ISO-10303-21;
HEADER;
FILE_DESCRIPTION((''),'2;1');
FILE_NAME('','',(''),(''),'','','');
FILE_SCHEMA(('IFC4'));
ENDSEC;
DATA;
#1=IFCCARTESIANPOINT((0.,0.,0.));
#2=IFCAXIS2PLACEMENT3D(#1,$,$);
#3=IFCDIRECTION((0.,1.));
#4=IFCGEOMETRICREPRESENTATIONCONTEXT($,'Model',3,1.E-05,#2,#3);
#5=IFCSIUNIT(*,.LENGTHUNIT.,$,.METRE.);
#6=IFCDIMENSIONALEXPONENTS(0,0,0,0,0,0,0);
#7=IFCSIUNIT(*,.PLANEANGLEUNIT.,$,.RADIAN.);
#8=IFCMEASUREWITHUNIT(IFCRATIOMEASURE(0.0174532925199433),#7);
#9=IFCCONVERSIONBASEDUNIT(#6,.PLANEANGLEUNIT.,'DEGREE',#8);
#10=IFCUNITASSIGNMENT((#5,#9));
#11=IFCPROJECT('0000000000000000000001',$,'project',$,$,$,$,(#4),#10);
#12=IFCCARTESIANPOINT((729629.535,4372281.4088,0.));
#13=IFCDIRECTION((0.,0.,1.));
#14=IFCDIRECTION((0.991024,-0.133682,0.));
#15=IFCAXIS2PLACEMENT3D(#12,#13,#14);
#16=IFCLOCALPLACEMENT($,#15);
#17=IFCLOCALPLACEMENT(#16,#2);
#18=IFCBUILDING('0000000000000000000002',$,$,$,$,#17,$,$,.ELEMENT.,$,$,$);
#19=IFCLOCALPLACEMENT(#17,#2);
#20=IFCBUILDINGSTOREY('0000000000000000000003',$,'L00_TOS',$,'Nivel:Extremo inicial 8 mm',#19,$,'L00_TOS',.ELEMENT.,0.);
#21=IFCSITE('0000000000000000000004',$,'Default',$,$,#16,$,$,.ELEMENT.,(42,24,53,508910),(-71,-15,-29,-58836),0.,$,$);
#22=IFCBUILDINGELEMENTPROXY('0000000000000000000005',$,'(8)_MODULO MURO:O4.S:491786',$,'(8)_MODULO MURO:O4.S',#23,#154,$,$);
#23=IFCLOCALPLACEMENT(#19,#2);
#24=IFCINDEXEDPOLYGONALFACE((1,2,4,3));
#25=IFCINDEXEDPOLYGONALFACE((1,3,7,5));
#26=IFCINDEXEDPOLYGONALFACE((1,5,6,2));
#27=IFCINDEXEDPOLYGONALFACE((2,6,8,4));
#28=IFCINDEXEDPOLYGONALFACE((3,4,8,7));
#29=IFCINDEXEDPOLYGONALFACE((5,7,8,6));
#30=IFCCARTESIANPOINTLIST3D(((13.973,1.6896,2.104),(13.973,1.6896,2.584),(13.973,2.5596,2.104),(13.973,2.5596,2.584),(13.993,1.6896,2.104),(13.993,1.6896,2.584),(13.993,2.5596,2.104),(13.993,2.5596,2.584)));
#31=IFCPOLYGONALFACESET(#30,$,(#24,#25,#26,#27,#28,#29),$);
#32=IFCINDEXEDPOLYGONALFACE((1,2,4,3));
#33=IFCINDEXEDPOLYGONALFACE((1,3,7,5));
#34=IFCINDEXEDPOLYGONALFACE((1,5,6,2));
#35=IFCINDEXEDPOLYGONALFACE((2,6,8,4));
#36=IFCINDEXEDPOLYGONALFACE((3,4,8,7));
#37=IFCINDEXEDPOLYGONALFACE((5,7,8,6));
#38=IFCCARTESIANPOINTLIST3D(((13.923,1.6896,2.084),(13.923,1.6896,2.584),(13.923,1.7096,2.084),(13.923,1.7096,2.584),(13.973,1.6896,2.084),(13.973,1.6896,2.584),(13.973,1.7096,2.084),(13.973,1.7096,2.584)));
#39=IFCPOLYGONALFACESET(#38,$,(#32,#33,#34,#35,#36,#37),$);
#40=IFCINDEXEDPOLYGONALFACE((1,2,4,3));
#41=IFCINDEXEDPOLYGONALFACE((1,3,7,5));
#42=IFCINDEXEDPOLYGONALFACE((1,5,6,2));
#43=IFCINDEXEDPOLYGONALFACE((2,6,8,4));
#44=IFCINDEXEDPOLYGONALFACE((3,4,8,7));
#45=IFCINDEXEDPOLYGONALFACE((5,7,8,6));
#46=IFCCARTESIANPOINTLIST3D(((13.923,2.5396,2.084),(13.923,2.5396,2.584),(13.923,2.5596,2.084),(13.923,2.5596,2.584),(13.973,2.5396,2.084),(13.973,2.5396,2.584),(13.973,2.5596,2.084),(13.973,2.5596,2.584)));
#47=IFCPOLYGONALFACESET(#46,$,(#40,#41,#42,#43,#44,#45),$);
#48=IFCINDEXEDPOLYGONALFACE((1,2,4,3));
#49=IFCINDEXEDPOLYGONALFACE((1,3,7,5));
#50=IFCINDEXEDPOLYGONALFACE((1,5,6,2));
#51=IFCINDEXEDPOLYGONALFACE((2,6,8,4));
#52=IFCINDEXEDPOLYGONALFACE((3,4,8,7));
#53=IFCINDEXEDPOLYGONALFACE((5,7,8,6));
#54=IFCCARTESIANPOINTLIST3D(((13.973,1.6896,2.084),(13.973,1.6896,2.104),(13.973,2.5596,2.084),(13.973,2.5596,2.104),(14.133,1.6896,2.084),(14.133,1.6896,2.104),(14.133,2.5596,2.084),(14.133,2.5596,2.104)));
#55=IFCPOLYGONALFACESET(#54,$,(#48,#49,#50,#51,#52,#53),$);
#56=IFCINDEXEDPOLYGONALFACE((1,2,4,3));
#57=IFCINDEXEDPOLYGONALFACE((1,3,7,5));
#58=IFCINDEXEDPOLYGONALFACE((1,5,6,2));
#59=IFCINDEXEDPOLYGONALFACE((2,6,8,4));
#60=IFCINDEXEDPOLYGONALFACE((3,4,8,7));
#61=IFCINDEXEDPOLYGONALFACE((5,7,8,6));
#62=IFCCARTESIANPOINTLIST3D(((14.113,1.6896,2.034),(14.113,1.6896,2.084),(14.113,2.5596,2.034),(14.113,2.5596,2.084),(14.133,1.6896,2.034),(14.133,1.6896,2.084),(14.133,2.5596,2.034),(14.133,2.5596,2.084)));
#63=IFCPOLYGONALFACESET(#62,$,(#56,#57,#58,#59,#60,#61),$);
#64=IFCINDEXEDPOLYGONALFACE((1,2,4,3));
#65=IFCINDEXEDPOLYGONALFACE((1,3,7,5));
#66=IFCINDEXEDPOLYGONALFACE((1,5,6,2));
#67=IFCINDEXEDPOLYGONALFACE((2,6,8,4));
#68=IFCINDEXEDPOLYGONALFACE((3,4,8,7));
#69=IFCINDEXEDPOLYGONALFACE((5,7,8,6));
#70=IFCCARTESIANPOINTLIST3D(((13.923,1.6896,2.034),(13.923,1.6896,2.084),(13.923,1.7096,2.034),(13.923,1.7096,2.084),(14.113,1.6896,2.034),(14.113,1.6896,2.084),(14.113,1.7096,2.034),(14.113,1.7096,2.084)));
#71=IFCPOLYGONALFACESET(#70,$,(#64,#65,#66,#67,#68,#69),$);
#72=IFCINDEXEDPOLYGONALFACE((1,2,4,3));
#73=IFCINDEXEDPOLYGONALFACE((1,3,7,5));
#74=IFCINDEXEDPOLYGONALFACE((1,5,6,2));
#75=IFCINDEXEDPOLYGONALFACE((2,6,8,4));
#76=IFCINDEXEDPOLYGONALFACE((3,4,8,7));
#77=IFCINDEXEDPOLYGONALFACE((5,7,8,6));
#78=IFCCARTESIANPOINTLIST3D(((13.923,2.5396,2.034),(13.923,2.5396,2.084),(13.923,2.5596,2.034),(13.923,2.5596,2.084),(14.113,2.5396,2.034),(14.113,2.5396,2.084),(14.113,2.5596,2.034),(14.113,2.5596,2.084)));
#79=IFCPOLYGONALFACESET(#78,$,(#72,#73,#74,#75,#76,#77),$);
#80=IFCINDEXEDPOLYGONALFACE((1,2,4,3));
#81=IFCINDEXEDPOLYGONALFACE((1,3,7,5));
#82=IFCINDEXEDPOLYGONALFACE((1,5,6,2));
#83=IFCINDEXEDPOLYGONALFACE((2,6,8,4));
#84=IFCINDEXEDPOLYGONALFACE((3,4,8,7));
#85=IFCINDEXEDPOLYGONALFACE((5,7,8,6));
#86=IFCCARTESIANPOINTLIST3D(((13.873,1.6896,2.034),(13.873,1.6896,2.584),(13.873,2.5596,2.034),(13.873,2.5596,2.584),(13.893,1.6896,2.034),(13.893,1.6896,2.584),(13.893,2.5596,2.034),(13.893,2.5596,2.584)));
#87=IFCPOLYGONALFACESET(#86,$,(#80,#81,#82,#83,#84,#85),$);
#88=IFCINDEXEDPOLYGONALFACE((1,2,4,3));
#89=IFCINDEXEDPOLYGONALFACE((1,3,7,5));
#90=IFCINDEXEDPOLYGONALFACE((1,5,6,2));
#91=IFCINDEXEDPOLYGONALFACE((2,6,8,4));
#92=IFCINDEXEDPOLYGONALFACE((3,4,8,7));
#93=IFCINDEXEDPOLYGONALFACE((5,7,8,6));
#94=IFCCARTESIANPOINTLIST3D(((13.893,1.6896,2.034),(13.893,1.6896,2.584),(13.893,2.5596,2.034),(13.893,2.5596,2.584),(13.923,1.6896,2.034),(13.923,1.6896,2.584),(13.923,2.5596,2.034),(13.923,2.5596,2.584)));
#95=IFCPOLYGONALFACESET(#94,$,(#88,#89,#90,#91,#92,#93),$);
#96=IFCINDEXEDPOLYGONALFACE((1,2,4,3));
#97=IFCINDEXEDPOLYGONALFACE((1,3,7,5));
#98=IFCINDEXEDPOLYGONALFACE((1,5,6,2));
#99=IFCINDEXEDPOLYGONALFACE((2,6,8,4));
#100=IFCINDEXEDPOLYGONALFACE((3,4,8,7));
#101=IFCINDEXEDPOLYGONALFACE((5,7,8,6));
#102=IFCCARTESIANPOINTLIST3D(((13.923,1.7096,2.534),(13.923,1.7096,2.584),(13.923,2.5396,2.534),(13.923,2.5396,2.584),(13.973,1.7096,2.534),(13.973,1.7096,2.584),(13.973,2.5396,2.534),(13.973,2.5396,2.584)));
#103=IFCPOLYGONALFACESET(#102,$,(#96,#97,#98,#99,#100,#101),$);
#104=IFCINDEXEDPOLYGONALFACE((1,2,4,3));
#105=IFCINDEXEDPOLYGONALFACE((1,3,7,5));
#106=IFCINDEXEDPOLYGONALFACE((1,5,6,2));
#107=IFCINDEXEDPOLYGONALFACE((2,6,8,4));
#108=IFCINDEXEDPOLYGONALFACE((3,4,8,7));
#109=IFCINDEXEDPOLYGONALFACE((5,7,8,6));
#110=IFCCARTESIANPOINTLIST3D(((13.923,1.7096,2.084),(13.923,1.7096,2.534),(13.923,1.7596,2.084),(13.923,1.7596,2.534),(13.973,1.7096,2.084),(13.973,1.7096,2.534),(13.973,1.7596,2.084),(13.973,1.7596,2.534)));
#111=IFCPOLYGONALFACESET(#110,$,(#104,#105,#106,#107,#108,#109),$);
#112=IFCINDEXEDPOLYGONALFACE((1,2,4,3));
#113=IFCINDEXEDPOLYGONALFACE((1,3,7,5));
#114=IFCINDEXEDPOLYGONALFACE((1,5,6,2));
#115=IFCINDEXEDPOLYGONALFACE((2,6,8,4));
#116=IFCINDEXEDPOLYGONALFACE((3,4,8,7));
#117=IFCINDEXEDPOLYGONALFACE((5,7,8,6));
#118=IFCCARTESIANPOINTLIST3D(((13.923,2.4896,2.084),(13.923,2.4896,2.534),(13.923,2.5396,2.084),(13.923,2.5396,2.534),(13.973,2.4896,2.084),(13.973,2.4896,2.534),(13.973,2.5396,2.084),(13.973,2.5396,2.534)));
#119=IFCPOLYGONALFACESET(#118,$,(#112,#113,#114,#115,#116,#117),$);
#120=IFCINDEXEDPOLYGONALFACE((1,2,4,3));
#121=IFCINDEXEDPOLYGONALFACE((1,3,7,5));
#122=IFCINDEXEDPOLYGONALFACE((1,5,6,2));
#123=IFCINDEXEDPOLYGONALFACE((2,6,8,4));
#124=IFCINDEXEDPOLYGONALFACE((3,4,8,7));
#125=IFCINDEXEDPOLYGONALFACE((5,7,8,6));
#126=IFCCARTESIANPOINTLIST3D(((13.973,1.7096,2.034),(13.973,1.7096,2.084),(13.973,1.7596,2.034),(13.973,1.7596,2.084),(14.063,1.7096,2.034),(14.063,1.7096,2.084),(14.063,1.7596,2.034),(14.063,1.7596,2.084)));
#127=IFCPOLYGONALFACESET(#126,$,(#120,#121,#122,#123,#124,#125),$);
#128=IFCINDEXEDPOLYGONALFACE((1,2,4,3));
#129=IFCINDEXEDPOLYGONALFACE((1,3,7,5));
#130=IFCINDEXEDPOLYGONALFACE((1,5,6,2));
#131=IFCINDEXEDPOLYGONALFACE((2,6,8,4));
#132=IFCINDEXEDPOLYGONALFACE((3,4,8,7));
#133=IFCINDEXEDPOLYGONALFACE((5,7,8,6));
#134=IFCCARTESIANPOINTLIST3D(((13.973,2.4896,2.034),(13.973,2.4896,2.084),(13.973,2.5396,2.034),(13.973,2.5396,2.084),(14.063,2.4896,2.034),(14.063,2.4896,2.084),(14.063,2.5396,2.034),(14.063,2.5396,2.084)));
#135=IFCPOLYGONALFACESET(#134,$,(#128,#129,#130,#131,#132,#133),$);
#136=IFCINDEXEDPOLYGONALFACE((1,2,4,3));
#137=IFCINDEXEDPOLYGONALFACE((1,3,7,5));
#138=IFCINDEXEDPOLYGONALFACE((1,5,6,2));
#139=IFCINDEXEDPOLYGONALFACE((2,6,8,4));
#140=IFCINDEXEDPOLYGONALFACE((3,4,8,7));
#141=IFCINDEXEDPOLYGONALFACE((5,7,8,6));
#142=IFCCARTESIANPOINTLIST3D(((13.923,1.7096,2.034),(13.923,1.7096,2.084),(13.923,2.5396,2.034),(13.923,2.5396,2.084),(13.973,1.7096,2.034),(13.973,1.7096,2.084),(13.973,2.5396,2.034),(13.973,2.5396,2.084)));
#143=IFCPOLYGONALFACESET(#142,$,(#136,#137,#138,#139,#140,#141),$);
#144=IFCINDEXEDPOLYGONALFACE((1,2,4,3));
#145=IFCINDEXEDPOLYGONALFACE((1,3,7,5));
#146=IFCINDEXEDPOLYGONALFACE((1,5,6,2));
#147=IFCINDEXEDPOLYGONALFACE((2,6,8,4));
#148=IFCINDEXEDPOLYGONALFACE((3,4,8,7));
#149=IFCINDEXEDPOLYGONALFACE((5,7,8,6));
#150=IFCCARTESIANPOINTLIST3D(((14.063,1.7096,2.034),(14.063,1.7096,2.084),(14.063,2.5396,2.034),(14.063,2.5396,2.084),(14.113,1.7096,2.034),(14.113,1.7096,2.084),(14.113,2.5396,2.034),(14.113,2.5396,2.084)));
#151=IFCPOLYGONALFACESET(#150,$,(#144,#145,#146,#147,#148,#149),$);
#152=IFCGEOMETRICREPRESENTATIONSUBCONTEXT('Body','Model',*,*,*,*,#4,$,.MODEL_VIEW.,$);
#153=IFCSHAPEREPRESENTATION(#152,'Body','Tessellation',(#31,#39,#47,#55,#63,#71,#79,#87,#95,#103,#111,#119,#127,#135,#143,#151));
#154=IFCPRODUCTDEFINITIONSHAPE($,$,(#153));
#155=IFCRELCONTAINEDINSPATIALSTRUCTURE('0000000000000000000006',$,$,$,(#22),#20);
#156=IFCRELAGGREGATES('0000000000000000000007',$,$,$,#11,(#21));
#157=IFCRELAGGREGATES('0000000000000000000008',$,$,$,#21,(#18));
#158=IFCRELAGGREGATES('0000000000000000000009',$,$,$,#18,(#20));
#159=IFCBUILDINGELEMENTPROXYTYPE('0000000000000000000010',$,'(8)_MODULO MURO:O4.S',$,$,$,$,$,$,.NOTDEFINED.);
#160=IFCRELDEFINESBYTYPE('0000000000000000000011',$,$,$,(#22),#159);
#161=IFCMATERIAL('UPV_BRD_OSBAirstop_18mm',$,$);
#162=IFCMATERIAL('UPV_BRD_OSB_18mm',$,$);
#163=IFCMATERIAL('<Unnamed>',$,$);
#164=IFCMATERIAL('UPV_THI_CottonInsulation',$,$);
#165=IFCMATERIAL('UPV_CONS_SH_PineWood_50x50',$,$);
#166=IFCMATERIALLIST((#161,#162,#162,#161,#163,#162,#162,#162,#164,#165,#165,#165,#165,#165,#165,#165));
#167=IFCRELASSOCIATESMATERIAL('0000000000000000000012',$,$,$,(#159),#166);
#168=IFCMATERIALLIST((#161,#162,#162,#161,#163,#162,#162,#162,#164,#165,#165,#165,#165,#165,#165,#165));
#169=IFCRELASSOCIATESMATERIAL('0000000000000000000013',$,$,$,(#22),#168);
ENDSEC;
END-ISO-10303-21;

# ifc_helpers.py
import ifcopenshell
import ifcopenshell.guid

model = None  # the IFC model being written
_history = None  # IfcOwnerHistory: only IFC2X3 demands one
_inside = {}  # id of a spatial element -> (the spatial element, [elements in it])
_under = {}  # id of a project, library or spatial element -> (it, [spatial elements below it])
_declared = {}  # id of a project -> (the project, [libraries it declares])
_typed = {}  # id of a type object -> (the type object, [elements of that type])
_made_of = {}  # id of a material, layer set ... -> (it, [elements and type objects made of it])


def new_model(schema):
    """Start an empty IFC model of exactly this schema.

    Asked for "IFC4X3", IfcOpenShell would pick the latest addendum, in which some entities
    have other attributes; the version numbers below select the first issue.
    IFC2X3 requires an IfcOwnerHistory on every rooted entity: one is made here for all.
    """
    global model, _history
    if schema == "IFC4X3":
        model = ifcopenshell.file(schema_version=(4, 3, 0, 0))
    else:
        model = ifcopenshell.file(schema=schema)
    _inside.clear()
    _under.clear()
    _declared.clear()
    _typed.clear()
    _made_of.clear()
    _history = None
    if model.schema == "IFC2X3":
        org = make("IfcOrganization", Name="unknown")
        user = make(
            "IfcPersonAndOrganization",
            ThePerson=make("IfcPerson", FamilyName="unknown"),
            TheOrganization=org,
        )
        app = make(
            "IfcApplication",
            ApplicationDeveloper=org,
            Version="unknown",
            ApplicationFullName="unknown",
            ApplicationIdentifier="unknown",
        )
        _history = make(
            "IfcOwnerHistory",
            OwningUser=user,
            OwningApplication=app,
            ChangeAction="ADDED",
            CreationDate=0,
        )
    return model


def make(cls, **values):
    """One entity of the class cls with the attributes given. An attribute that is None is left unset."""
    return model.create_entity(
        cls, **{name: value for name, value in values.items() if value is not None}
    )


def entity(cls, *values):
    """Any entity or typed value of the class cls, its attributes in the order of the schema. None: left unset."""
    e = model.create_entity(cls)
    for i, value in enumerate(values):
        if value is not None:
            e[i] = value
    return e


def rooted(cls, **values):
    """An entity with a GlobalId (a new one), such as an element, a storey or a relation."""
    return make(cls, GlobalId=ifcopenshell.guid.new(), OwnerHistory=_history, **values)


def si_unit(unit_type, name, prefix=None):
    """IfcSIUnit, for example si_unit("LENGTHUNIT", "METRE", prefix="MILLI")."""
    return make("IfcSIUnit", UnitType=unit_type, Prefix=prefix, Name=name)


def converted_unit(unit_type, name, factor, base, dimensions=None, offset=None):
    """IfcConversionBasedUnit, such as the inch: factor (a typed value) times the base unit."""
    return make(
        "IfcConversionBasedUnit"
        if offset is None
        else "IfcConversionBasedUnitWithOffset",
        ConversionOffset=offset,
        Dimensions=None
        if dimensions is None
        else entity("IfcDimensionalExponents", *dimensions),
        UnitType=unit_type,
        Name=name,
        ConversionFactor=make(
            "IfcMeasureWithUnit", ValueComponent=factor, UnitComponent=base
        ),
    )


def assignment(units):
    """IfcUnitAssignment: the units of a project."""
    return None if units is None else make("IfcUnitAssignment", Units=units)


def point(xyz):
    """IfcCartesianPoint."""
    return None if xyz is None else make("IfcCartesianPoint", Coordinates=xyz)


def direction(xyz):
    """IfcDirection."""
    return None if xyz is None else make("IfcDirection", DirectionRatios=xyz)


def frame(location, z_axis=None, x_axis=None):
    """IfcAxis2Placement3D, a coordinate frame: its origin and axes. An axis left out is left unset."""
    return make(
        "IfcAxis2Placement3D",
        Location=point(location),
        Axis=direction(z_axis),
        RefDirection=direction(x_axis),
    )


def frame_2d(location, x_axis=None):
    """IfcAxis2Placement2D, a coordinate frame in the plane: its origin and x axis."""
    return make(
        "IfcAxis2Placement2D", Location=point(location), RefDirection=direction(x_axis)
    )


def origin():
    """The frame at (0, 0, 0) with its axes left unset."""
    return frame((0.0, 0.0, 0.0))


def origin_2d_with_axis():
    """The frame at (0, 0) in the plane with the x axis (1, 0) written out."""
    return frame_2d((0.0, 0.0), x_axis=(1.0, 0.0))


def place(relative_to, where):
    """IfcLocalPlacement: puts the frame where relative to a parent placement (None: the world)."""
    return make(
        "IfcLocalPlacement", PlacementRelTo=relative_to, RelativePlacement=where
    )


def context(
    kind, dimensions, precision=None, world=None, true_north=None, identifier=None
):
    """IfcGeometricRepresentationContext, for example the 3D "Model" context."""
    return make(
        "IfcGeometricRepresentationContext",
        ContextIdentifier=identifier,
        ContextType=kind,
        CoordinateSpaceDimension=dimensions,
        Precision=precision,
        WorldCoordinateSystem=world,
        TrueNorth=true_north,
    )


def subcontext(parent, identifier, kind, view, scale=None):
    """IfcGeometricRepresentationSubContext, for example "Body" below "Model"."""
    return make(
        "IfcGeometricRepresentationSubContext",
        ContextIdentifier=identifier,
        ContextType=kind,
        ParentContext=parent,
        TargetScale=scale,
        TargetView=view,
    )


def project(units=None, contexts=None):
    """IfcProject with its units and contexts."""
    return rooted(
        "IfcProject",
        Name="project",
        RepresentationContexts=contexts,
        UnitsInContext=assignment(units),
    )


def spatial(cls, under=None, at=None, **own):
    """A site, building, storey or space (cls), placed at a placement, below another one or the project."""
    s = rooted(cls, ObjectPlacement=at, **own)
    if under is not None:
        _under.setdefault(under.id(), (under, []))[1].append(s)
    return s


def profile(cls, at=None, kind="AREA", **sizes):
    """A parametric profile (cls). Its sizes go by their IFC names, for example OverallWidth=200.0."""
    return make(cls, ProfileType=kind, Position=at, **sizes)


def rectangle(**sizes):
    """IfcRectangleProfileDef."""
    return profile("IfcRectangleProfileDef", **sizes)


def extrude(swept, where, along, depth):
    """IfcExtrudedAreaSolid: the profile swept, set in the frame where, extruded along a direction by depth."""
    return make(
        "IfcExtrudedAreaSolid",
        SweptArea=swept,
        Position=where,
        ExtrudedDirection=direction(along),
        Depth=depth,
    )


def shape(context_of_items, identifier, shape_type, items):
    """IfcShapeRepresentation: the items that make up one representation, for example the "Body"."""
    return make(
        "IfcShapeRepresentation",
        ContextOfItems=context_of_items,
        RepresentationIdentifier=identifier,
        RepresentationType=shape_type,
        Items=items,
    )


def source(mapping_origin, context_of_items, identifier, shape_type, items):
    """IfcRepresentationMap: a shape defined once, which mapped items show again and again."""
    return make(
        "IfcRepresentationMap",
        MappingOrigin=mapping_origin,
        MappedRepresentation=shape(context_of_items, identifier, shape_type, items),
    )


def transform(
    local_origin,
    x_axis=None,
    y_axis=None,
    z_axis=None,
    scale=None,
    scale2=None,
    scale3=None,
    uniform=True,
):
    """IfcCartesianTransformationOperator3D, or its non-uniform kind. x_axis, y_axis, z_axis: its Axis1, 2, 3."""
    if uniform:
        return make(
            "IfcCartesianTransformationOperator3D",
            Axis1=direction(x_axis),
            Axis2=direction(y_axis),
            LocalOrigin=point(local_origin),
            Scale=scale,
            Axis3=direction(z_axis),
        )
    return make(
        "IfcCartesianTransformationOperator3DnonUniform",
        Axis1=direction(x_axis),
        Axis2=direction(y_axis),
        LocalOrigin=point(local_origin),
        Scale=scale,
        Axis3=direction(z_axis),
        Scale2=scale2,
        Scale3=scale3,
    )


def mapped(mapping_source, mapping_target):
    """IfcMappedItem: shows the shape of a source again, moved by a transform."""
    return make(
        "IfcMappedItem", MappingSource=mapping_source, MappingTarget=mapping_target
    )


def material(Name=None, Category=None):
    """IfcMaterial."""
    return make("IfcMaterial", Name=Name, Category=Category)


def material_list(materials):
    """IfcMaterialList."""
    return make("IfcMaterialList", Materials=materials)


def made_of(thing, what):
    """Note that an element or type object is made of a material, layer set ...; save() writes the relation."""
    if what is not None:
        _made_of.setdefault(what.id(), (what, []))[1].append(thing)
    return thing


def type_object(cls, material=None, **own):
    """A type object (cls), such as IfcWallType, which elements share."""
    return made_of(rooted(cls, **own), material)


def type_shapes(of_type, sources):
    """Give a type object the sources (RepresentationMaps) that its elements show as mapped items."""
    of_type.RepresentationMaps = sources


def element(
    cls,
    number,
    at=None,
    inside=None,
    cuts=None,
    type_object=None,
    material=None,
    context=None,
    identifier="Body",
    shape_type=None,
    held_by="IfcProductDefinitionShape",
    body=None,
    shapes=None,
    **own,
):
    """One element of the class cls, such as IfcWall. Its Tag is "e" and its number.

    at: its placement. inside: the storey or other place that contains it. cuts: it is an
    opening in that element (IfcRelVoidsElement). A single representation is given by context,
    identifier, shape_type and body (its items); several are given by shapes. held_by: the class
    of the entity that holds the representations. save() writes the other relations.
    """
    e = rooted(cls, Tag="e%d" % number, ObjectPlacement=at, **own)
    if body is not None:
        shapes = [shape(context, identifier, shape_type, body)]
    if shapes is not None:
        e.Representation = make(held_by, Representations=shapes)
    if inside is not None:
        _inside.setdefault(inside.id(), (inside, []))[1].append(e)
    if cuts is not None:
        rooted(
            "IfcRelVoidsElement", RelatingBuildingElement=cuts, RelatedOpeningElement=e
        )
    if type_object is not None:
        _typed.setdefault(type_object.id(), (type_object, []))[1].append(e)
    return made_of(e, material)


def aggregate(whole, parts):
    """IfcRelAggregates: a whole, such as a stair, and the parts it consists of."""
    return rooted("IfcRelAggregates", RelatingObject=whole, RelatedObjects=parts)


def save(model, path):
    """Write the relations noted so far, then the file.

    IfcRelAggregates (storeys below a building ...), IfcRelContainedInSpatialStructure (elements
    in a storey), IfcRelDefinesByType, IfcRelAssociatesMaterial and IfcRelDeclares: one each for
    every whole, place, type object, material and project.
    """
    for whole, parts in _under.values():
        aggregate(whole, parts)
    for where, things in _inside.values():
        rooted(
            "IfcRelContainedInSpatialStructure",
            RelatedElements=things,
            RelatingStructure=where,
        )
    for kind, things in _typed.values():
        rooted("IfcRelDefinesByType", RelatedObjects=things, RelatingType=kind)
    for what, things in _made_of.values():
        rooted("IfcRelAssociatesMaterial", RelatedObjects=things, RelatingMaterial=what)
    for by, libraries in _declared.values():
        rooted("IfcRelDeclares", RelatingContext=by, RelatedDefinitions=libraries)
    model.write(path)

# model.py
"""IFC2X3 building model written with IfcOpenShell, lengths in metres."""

from ifc_helpers import new_model, entity, si_unit, converted_unit, direction, frame, frame_2d, origin, origin_2d_with_axis, place, context, subcontext, project, spatial, rectangle, extrude, source, transform, mapped, material, material_list, type_object, type_shapes, element, save


model = new_model("IFC2X3")

# Units and contexts
model_context = context("Model", 3, precision=1e-05, world=origin(), true_north=direction((0.0, 1.0)))
body_context = subcontext(model_context, "Body", "Model", "MODEL_VIEW")
ifc_project = project(units=[si_unit("LENGTHUNIT", "METRE"), converted_unit("PLANEANGLEUNIT", "DEGREE", entity("IfcRatioMeasure", 0.0174532925199433), si_unit("PLANEANGLEUNIT", "RADIAN"), dimensions=[0, 0, 0, 0, 0, 0, 0])], contexts=[model_context])

# Site, building, storey
site_placement = place(None, frame((729629.535, 4372281.4088, 0.0), z_axis=(0.0, 0.0, 1.0), x_axis=(0.991024, -0.133682, 0.0)))
site = spatial("IfcSite", under=ifc_project, at=site_placement, Name="Default", CompositionType="ELEMENT", RefLatitude=(42, 24, 53, 508910), RefLongitude=(-71, -15, -29, -58836), RefElevation=0.0)
building_placement = place(site_placement, origin())
building = spatial("IfcBuilding", under=site, at=building_placement, CompositionType="ELEMENT")
storey_placement = place(building_placement, origin())
storey = spatial("IfcBuildingStorey", under=building, at=storey_placement, Name="L00_TOS", ObjectType="Nivel:Extremo inicial 8 mm", LongName="L00_TOS", CompositionType="ELEMENT", Elevation=0.0)

# Building element proxy
ifc_material_1 = material(Name="UPV_BRD_OSBAirstop_18mm")
ifc_material_2 = material(Name="UPV_BRD_OSB_18mm")
ifc_material_3 = material(Name="UPV_THI_CottonInsulation")
ifc_material_4 = material(Name="<Unnamed>")
ifc_material_5 = material(Name="UPV_CONS_SH_PineWood_50x50")
ifc_material_list_1 = material_list([ifc_material_1, ifc_material_2, ifc_material_2, ifc_material_1, ifc_material_4, ifc_material_2, ifc_material_2, ifc_material_2, ifc_material_3, ifc_material_5, ifc_material_5, ifc_material_5, ifc_material_5, ifc_material_5, ifc_material_5, ifc_material_5])
ifc_material_list_2 = material_list([ifc_material_1, ifc_material_2, ifc_material_2, ifc_material_1, ifc_material_4, ifc_material_2, ifc_material_2, ifc_material_2, ifc_material_3, ifc_material_5, ifc_material_5, ifc_material_5, ifc_material_5, ifc_material_5, ifc_material_5, ifc_material_5])
building_element_proxy_type_1 = type_object("IfcBuildingElementProxyType", Name="(8)_MODULO MURO:O4.S", PredefinedType="NOTDEFINED", material=ifc_material_list_2)
shared_shape_1 = source(origin(), body_context, "Body", "SweptSolid", [
    extrude(rectangle(XDim=0.87, YDim=0.02, at=frame_2d((0.0, 0.0), x_axis=(1.0, 0.0))), frame((0.0, 0.035, 0.07), z_axis=(0.0, 0.0, 1.0), x_axis=(-1.0, 0.0, 0.0)), (0.0, 0.0, 1.0), 0.48),
    extrude(rectangle(XDim=0.05, YDim=0.02, at=frame_2d((0.0, 0.0), x_axis=(1.0, 0.0))), frame((-0.425, 0.07, 0.05), z_axis=(0.0, 0.0, 1.0), x_axis=(0.0, -1.0, 0.0)), (0.0, 0.0, 1.0), 0.5),
    extrude(rectangle(XDim=0.05, YDim=0.02, at=origin_2d_with_axis()), frame((0.425, 0.07, 0.05), z_axis=(0.0, 0.0, 1.0), x_axis=(0.0, -1.0, 0.0)), (0.0, 0.0, 1.0), 0.5),
    extrude(rectangle(XDim=0.87, YDim=0.16, at=origin_2d_with_axis()), frame((0.0, -0.035, 0.05)), (0.0, 0.0, 1.0), 0.02),
    extrude(rectangle(XDim=0.87, YDim=0.02, at=origin_2d_with_axis()), frame((0.0, -0.105, 0.0), z_axis=(0.0, 0.0, 1.0), x_axis=(-1.0, 0.0, 0.0)), (0.0, 0.0, 1.0), 0.05),
    extrude(rectangle(XDim=0.19, YDim=0.02, at=frame_2d((0.0, 0.0), x_axis=(1.0, 0.0))), frame((-0.425, 0.0, 0.0), z_axis=(0.0, 0.0, 1.0), x_axis=(0.0, -1.0, 0.0)), (0.0, 0.0, 1.0), 0.05),
    extrude(rectangle(XDim=0.19, YDim=0.02, at=origin_2d_with_axis()), frame((0.425, 0.0, 0.0), z_axis=(0.0, 0.0, 1.0), x_axis=(0.0, -1.0, 0.0)), (0.0, 0.0, 1.0), 0.05),
    extrude(rectangle(XDim=0.87, YDim=0.02, at=frame_2d((0.0, 0.0), x_axis=(1.0, 0.0))), frame((0.0, 0.135, 0.0), z_axis=(0.0, 0.0, 1.0), x_axis=(-1.0, 0.0, 0.0)), (0.0, 0.0, 1.0), 0.55),
    extrude(rectangle(XDim=0.87, YDim=0.03, at=origin_2d_with_axis()), frame((0.0, 0.11, 0.0)), (0.0, 0.0, 1.0), 0.55),
    extrude(rectangle(XDim=0.05, YDim=0.83, at=origin_2d_with_axis()), frame((0.0, 0.07, 0.5), z_axis=(0.0, 0.0, 1.0), x_axis=(0.0, -1.0, 0.0)), (0.0, 0.0, 1.0), 0.05),
    extrude(rectangle(XDim=0.05, YDim=0.05, at=origin_2d_with_axis()), frame((-0.39, 0.07, 0.05)), (0.0, 0.0, 1.0), 0.45),
    extrude(rectangle(XDim=0.05, YDim=0.05, at=origin_2d_with_axis()), frame((0.39, 0.07, 0.05), z_axis=(0.0, 0.0, 1.0), x_axis=(0.0, -1.0, 0.0)), (0.0, 0.0, 1.0), 0.45),
    extrude(rectangle(XDim=0.09, YDim=0.05, at=origin_2d_with_axis()), frame((-0.39, 0.0, 0.0), z_axis=(0.0, 0.0, 1.0), x_axis=(0.0, -1.0, 0.0)), (0.0, 0.0, 1.0), 0.05),
    extrude(rectangle(XDim=0.09, YDim=0.05, at=origin_2d_with_axis()), frame((0.39, 0.0, 0.0), z_axis=(0.0, 0.0, 1.0), x_axis=(0.0, -1.0, 0.0)), (0.0, 0.0, 1.0), 0.05),
    extrude(rectangle(XDim=0.05, YDim=0.83, at=origin_2d_with_axis()), frame((0.0, 0.07, 0.0), z_axis=(0.0, 0.0, 1.0), x_axis=(0.0, -1.0, 0.0)), (0.0, 0.0, 1.0), 0.05),
    extrude(rectangle(XDim=0.05, YDim=0.83, at=origin_2d_with_axis()), frame((0.0, -0.07, 0.0), z_axis=(0.0, 0.0, 1.0), x_axis=(0.0, -1.0, 0.0)), (0.0, 0.0, 1.0), 0.05),
])
type_shapes(building_element_proxy_type_1, [shared_shape_1])
proxy_1_placement = place(storey_placement, frame((14.018, 2.1246, 2.034), z_axis=(0.0, 0.0, 1.0), x_axis=(0.0, 1.0, 0.0)))
element("IfcBuildingElementProxy", 1, at=proxy_1_placement, inside=storey, type_object=building_element_proxy_type_1, material=ifc_material_list_1, Name="(8)_MODULO MURO:O4.S:491786", ObjectType="(8)_MODULO MURO:O4.S", context=body_context, shape_type="MappedRepresentation", body=[
    mapped(shared_shape_1, transform((0.0, 0.0, 0.0), scale=1.0)),
])

save(model, "model.ifc")
